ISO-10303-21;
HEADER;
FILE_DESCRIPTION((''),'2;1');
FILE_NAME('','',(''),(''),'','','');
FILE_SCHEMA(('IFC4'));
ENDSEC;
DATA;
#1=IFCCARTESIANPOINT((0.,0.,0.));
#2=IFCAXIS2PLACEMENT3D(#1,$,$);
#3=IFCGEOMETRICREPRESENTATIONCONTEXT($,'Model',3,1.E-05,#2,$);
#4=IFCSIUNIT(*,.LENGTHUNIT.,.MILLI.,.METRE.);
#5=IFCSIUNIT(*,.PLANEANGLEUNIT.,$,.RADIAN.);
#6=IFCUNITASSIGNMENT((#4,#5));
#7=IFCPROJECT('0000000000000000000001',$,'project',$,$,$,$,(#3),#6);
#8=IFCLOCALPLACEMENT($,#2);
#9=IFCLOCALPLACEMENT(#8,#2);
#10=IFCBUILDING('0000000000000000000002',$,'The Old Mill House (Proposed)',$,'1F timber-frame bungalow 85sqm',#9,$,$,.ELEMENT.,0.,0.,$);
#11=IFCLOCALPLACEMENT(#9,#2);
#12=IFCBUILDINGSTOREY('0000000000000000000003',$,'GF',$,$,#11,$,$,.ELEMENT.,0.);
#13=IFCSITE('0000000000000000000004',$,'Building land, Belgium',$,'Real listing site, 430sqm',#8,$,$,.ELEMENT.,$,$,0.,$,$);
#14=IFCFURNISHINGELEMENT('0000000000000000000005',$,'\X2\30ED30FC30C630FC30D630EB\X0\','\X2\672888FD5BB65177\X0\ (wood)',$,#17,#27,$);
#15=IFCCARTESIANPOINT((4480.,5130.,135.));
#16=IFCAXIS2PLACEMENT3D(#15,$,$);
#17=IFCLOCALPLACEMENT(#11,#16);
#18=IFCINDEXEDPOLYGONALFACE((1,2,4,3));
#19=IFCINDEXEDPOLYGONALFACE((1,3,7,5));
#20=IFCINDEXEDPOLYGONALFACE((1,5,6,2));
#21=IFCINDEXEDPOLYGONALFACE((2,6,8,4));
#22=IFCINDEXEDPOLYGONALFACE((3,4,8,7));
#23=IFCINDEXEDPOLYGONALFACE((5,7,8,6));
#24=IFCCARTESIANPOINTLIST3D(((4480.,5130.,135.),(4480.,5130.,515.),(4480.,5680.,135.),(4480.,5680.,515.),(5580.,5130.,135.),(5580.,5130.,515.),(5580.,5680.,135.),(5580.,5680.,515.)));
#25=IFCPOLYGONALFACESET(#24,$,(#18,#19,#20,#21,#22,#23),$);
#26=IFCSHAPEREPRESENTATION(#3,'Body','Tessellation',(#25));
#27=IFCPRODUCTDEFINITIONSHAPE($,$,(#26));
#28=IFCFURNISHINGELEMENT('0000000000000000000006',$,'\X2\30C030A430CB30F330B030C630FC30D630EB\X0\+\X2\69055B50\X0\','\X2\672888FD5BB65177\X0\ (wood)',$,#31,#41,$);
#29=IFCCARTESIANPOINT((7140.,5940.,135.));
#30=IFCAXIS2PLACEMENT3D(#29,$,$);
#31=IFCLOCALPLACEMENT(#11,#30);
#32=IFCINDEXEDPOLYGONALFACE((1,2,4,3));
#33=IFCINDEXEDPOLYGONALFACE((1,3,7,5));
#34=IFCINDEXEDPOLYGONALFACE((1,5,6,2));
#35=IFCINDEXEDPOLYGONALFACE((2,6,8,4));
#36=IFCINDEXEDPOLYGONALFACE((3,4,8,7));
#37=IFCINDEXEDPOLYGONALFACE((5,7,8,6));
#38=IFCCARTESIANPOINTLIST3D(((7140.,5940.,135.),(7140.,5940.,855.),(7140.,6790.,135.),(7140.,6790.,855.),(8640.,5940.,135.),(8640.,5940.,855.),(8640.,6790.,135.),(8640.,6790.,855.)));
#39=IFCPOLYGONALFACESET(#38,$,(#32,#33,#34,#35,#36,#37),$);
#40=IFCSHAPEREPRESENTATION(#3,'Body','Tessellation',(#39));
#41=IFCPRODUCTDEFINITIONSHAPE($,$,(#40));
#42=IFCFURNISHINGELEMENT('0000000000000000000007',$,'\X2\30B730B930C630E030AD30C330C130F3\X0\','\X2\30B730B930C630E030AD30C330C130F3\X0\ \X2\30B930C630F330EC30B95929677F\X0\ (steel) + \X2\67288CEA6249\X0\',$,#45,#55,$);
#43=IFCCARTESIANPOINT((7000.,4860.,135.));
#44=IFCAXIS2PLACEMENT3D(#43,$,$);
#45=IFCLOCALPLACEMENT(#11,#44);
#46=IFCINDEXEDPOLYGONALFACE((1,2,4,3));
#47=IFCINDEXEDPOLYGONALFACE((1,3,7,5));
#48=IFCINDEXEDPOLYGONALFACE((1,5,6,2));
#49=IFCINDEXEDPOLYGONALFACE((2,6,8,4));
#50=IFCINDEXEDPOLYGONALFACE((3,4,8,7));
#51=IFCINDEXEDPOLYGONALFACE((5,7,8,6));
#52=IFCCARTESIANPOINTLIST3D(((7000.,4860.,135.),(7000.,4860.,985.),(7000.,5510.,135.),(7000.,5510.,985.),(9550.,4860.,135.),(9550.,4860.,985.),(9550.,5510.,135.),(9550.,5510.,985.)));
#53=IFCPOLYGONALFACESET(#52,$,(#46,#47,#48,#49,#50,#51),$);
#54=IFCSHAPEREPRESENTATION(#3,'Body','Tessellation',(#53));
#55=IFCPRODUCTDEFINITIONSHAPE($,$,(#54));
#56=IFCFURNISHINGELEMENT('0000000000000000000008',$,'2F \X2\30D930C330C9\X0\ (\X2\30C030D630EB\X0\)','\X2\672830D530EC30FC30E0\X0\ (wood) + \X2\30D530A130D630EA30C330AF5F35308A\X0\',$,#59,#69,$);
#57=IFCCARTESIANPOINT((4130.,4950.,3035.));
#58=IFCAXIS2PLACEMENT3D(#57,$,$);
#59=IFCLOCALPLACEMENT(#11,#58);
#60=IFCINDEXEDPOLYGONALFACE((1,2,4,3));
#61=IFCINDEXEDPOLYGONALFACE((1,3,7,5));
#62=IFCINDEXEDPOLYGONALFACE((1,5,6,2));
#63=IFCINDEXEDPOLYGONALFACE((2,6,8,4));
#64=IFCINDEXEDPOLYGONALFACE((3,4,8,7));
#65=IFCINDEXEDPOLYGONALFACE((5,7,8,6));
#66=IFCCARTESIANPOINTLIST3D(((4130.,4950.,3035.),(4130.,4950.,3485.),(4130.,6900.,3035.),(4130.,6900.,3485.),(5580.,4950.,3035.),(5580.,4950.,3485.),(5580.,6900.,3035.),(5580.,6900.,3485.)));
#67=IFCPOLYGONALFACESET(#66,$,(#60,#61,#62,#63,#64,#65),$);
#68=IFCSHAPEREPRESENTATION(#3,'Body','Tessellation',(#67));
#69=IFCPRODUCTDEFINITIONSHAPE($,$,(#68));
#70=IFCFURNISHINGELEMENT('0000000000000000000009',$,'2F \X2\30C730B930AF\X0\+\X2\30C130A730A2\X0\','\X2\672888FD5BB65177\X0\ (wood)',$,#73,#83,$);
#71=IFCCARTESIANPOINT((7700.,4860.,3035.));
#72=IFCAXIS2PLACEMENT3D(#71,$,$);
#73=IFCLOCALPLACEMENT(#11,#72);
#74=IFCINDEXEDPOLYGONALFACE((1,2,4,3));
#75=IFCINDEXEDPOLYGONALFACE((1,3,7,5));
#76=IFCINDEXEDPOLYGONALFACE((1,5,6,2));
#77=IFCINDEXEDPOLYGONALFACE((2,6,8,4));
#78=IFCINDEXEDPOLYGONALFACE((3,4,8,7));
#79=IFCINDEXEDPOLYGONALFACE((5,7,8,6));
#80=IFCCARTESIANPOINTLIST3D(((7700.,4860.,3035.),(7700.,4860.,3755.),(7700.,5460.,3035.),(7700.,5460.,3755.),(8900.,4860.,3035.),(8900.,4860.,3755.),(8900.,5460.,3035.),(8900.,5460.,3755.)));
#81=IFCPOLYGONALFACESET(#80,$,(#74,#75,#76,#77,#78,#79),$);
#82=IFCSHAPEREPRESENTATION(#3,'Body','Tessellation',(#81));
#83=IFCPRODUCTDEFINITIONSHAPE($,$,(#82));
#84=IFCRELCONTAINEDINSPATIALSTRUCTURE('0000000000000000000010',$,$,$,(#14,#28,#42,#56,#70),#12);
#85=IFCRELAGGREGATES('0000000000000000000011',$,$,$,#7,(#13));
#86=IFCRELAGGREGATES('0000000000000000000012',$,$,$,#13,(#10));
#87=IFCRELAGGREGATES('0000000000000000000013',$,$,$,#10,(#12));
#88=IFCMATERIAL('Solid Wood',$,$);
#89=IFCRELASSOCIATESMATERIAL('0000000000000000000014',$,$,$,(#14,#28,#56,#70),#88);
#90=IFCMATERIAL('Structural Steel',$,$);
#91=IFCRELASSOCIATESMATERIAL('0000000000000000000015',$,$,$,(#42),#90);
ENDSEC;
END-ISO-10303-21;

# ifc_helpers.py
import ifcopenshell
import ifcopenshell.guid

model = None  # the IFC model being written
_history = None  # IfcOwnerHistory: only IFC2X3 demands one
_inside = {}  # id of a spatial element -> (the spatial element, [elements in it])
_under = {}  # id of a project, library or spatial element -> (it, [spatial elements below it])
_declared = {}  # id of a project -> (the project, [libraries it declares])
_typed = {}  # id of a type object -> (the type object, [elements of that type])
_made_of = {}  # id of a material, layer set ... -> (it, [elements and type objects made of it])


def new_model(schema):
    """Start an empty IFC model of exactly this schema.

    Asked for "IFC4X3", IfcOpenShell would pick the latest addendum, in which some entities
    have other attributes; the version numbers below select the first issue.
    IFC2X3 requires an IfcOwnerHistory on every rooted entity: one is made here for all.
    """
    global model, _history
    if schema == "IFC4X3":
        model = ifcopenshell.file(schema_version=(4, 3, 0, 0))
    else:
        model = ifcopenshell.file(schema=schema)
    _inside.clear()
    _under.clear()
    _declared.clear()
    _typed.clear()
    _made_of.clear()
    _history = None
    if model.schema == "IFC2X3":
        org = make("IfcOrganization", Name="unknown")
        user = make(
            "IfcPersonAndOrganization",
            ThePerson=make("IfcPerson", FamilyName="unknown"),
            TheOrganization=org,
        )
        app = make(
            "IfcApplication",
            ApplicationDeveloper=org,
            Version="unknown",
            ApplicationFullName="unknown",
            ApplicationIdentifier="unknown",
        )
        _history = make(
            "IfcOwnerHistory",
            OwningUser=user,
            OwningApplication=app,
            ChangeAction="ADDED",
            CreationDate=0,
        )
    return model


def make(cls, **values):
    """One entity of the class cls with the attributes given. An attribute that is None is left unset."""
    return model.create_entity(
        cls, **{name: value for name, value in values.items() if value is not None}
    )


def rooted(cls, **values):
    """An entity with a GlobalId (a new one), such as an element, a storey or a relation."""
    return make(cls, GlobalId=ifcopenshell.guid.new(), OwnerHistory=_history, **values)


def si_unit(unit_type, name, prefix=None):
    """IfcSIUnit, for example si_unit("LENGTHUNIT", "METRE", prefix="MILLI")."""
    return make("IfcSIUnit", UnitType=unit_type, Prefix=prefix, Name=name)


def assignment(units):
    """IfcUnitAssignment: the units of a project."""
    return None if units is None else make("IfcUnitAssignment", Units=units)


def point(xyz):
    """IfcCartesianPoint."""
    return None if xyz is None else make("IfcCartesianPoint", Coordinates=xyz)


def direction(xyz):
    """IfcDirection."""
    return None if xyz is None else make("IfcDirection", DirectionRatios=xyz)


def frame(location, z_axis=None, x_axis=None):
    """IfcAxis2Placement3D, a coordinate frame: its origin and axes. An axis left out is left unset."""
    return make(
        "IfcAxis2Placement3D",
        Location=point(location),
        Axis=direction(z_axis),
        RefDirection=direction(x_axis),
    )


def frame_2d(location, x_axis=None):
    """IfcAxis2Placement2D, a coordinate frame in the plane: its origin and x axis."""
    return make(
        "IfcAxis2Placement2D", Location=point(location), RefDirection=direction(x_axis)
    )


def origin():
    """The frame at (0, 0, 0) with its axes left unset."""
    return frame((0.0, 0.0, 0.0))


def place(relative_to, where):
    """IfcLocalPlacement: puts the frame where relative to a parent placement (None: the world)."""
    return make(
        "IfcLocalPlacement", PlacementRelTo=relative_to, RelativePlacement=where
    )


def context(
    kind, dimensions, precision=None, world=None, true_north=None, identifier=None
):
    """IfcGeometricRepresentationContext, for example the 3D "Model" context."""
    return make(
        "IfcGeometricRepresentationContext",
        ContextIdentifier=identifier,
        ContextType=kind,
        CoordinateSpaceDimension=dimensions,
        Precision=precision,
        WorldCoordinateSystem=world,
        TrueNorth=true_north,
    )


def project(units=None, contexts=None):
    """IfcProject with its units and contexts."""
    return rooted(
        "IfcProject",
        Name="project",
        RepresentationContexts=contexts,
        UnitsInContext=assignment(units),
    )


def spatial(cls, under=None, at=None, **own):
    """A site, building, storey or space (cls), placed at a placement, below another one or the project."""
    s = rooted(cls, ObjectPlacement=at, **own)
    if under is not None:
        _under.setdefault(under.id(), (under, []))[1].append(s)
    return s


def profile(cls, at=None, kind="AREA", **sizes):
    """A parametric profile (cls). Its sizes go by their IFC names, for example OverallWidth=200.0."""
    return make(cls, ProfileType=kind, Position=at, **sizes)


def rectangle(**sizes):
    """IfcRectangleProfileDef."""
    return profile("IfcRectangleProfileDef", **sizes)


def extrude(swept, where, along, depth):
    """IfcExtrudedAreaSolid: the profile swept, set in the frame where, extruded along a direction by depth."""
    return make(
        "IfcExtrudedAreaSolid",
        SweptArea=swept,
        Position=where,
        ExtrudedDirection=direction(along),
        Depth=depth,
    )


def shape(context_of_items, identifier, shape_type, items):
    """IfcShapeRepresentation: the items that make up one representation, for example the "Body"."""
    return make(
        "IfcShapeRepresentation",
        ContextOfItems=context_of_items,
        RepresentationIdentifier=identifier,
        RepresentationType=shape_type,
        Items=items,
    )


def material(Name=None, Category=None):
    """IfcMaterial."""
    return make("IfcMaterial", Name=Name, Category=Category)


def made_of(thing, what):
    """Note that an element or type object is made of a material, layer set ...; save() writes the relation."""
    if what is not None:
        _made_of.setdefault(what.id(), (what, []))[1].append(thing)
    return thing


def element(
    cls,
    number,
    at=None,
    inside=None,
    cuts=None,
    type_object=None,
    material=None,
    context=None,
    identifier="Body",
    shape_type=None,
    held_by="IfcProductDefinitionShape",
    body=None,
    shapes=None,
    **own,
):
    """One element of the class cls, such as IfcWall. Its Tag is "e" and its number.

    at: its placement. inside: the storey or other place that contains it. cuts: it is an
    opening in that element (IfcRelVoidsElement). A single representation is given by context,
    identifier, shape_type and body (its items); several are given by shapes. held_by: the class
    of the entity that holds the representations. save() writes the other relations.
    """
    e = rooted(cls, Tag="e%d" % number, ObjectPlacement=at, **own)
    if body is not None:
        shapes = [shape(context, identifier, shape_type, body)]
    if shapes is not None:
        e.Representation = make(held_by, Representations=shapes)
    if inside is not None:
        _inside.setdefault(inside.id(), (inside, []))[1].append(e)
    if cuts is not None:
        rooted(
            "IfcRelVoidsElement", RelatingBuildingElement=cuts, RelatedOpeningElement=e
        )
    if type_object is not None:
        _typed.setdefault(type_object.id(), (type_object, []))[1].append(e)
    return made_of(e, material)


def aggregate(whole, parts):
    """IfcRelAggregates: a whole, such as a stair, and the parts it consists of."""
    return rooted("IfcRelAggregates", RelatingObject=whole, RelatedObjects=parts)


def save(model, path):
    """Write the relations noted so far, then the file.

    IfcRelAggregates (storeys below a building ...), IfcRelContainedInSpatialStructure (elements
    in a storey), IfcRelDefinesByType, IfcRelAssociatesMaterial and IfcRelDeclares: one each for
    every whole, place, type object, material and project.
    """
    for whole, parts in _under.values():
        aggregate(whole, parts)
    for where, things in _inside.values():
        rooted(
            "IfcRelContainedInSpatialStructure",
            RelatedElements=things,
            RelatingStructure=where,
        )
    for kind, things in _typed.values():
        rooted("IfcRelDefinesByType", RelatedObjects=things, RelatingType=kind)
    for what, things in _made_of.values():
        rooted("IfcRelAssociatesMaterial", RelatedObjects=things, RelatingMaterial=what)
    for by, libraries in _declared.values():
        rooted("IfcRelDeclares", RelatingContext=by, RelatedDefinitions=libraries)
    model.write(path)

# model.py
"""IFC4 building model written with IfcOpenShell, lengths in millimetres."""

from ifc_helpers import new_model, si_unit, frame, frame_2d, origin, place, context, project, spatial, rectangle, extrude, material, element, save


model = new_model("IFC4")

# Units and contexts
model_context = context("Model", 3, precision=1e-05, world=origin())
ifc_project = project(units=[si_unit("LENGTHUNIT", "METRE", prefix="MILLI"), si_unit("PLANEANGLEUNIT", "RADIAN")], contexts=[model_context])

# Site, building, storey
site_placement = place(None, origin())
site = spatial("IfcSite", under=ifc_project, at=site_placement, Name="Building land, Belgium", ObjectType="Real listing site, 430sqm", CompositionType="ELEMENT", RefElevation=0.0)
building_placement = place(site_placement, origin())
building = spatial("IfcBuilding", under=site, at=building_placement, Name="The Old Mill House (Proposed)", ObjectType="1F timber-frame bungalow 85sqm", CompositionType="ELEMENT", ElevationOfRefHeight=0.0, ElevationOfTerrain=0.0)
storey_placement = place(building_placement, origin())
storey = spatial("IfcBuildingStorey", under=building, at=storey_placement, Name="GF", CompositionType="ELEMENT", Elevation=0.0)

# Shared definitions
ifc_material_1 = material(Name="Solid Wood")

# Shared definitions
ifc_material_2 = material(Name="Structural Steel")

# Furnishing elements
furnishing_1_placement = place(storey_placement, frame((4480.0, 5130.0, 135.0)))
element("IfcFurnishingElement", 1, at=furnishing_1_placement, inside=storey, material=ifc_material_1, Name="ローテーブル", Description="木製家具 (wood)", context=model_context, shape_type="SweptSolid", body=[
    extrude(rectangle(XDim=1100.0, YDim=550.0, at=frame_2d((550.0, 275.0))), frame((4480.0, 5130.0, 135.0)), (0.0, 0.0, 1.0), 380.0),
])
furnishing_2_placement = place(storey_placement, frame((7140.0, 5940.0, 135.0)))
element("IfcFurnishingElement", 2, at=furnishing_2_placement, inside=storey, material=ifc_material_1, Name="ダイニングテーブル+椅子", Description="木製家具 (wood)", context=model_context, shape_type="SweptSolid", body=[
    extrude(rectangle(XDim=1500.0, YDim=850.0, at=frame_2d((750.0, 425.0))), frame((7140.0, 5940.0, 135.0)), (0.0, 0.0, 1.0), 720.0),
])
furnishing_3_placement = place(storey_placement, frame((7000.0, 4860.0, 135.0)))
element("IfcFurnishingElement", 3, at=furnishing_3_placement, inside=storey, material=ifc_material_2, Name="システムキッチン", Description="システムキッチン ステンレス天板 (steel) + 木質扉", context=model_context, shape_type="SweptSolid", body=[
    extrude(rectangle(XDim=2550.0, YDim=650.0, at=frame_2d((1275.0, 325.0))), frame((7000.0, 4860.0, 135.0)), (0.0, 0.0, 1.0), 850.0),
])
furnishing_4_placement = place(storey_placement, frame((4130.0, 4950.0, 3035.0)))
element("IfcFurnishingElement", 4, at=furnishing_4_placement, inside=storey, material=ifc_material_1, Name="2F ベッド (ダブル)", Description="木フレーム (wood) + ファブリック張り", context=model_context, shape_type="SweptSolid", body=[
    extrude(rectangle(XDim=1450.0, YDim=1950.0, at=frame_2d((725.0, 975.0))), frame((4130.0, 4950.0, 3035.0)), (0.0, 0.0, 1.0), 450.0),
])
furnishing_5_placement = place(storey_placement, frame((7700.0, 4860.0, 3035.0)))
element("IfcFurnishingElement", 5, at=furnishing_5_placement, inside=storey, material=ifc_material_1, Name="2F デスク+チェア", Description="木製家具 (wood)", context=model_context, shape_type="SweptSolid", body=[
    extrude(rectangle(XDim=1200.0, YDim=600.0, at=frame_2d((600.0, 300.0))), frame((7700.0, 4860.0, 3035.0)), (0.0, 0.0, 1.0), 720.0),
])

save(model, "model.ifc")
